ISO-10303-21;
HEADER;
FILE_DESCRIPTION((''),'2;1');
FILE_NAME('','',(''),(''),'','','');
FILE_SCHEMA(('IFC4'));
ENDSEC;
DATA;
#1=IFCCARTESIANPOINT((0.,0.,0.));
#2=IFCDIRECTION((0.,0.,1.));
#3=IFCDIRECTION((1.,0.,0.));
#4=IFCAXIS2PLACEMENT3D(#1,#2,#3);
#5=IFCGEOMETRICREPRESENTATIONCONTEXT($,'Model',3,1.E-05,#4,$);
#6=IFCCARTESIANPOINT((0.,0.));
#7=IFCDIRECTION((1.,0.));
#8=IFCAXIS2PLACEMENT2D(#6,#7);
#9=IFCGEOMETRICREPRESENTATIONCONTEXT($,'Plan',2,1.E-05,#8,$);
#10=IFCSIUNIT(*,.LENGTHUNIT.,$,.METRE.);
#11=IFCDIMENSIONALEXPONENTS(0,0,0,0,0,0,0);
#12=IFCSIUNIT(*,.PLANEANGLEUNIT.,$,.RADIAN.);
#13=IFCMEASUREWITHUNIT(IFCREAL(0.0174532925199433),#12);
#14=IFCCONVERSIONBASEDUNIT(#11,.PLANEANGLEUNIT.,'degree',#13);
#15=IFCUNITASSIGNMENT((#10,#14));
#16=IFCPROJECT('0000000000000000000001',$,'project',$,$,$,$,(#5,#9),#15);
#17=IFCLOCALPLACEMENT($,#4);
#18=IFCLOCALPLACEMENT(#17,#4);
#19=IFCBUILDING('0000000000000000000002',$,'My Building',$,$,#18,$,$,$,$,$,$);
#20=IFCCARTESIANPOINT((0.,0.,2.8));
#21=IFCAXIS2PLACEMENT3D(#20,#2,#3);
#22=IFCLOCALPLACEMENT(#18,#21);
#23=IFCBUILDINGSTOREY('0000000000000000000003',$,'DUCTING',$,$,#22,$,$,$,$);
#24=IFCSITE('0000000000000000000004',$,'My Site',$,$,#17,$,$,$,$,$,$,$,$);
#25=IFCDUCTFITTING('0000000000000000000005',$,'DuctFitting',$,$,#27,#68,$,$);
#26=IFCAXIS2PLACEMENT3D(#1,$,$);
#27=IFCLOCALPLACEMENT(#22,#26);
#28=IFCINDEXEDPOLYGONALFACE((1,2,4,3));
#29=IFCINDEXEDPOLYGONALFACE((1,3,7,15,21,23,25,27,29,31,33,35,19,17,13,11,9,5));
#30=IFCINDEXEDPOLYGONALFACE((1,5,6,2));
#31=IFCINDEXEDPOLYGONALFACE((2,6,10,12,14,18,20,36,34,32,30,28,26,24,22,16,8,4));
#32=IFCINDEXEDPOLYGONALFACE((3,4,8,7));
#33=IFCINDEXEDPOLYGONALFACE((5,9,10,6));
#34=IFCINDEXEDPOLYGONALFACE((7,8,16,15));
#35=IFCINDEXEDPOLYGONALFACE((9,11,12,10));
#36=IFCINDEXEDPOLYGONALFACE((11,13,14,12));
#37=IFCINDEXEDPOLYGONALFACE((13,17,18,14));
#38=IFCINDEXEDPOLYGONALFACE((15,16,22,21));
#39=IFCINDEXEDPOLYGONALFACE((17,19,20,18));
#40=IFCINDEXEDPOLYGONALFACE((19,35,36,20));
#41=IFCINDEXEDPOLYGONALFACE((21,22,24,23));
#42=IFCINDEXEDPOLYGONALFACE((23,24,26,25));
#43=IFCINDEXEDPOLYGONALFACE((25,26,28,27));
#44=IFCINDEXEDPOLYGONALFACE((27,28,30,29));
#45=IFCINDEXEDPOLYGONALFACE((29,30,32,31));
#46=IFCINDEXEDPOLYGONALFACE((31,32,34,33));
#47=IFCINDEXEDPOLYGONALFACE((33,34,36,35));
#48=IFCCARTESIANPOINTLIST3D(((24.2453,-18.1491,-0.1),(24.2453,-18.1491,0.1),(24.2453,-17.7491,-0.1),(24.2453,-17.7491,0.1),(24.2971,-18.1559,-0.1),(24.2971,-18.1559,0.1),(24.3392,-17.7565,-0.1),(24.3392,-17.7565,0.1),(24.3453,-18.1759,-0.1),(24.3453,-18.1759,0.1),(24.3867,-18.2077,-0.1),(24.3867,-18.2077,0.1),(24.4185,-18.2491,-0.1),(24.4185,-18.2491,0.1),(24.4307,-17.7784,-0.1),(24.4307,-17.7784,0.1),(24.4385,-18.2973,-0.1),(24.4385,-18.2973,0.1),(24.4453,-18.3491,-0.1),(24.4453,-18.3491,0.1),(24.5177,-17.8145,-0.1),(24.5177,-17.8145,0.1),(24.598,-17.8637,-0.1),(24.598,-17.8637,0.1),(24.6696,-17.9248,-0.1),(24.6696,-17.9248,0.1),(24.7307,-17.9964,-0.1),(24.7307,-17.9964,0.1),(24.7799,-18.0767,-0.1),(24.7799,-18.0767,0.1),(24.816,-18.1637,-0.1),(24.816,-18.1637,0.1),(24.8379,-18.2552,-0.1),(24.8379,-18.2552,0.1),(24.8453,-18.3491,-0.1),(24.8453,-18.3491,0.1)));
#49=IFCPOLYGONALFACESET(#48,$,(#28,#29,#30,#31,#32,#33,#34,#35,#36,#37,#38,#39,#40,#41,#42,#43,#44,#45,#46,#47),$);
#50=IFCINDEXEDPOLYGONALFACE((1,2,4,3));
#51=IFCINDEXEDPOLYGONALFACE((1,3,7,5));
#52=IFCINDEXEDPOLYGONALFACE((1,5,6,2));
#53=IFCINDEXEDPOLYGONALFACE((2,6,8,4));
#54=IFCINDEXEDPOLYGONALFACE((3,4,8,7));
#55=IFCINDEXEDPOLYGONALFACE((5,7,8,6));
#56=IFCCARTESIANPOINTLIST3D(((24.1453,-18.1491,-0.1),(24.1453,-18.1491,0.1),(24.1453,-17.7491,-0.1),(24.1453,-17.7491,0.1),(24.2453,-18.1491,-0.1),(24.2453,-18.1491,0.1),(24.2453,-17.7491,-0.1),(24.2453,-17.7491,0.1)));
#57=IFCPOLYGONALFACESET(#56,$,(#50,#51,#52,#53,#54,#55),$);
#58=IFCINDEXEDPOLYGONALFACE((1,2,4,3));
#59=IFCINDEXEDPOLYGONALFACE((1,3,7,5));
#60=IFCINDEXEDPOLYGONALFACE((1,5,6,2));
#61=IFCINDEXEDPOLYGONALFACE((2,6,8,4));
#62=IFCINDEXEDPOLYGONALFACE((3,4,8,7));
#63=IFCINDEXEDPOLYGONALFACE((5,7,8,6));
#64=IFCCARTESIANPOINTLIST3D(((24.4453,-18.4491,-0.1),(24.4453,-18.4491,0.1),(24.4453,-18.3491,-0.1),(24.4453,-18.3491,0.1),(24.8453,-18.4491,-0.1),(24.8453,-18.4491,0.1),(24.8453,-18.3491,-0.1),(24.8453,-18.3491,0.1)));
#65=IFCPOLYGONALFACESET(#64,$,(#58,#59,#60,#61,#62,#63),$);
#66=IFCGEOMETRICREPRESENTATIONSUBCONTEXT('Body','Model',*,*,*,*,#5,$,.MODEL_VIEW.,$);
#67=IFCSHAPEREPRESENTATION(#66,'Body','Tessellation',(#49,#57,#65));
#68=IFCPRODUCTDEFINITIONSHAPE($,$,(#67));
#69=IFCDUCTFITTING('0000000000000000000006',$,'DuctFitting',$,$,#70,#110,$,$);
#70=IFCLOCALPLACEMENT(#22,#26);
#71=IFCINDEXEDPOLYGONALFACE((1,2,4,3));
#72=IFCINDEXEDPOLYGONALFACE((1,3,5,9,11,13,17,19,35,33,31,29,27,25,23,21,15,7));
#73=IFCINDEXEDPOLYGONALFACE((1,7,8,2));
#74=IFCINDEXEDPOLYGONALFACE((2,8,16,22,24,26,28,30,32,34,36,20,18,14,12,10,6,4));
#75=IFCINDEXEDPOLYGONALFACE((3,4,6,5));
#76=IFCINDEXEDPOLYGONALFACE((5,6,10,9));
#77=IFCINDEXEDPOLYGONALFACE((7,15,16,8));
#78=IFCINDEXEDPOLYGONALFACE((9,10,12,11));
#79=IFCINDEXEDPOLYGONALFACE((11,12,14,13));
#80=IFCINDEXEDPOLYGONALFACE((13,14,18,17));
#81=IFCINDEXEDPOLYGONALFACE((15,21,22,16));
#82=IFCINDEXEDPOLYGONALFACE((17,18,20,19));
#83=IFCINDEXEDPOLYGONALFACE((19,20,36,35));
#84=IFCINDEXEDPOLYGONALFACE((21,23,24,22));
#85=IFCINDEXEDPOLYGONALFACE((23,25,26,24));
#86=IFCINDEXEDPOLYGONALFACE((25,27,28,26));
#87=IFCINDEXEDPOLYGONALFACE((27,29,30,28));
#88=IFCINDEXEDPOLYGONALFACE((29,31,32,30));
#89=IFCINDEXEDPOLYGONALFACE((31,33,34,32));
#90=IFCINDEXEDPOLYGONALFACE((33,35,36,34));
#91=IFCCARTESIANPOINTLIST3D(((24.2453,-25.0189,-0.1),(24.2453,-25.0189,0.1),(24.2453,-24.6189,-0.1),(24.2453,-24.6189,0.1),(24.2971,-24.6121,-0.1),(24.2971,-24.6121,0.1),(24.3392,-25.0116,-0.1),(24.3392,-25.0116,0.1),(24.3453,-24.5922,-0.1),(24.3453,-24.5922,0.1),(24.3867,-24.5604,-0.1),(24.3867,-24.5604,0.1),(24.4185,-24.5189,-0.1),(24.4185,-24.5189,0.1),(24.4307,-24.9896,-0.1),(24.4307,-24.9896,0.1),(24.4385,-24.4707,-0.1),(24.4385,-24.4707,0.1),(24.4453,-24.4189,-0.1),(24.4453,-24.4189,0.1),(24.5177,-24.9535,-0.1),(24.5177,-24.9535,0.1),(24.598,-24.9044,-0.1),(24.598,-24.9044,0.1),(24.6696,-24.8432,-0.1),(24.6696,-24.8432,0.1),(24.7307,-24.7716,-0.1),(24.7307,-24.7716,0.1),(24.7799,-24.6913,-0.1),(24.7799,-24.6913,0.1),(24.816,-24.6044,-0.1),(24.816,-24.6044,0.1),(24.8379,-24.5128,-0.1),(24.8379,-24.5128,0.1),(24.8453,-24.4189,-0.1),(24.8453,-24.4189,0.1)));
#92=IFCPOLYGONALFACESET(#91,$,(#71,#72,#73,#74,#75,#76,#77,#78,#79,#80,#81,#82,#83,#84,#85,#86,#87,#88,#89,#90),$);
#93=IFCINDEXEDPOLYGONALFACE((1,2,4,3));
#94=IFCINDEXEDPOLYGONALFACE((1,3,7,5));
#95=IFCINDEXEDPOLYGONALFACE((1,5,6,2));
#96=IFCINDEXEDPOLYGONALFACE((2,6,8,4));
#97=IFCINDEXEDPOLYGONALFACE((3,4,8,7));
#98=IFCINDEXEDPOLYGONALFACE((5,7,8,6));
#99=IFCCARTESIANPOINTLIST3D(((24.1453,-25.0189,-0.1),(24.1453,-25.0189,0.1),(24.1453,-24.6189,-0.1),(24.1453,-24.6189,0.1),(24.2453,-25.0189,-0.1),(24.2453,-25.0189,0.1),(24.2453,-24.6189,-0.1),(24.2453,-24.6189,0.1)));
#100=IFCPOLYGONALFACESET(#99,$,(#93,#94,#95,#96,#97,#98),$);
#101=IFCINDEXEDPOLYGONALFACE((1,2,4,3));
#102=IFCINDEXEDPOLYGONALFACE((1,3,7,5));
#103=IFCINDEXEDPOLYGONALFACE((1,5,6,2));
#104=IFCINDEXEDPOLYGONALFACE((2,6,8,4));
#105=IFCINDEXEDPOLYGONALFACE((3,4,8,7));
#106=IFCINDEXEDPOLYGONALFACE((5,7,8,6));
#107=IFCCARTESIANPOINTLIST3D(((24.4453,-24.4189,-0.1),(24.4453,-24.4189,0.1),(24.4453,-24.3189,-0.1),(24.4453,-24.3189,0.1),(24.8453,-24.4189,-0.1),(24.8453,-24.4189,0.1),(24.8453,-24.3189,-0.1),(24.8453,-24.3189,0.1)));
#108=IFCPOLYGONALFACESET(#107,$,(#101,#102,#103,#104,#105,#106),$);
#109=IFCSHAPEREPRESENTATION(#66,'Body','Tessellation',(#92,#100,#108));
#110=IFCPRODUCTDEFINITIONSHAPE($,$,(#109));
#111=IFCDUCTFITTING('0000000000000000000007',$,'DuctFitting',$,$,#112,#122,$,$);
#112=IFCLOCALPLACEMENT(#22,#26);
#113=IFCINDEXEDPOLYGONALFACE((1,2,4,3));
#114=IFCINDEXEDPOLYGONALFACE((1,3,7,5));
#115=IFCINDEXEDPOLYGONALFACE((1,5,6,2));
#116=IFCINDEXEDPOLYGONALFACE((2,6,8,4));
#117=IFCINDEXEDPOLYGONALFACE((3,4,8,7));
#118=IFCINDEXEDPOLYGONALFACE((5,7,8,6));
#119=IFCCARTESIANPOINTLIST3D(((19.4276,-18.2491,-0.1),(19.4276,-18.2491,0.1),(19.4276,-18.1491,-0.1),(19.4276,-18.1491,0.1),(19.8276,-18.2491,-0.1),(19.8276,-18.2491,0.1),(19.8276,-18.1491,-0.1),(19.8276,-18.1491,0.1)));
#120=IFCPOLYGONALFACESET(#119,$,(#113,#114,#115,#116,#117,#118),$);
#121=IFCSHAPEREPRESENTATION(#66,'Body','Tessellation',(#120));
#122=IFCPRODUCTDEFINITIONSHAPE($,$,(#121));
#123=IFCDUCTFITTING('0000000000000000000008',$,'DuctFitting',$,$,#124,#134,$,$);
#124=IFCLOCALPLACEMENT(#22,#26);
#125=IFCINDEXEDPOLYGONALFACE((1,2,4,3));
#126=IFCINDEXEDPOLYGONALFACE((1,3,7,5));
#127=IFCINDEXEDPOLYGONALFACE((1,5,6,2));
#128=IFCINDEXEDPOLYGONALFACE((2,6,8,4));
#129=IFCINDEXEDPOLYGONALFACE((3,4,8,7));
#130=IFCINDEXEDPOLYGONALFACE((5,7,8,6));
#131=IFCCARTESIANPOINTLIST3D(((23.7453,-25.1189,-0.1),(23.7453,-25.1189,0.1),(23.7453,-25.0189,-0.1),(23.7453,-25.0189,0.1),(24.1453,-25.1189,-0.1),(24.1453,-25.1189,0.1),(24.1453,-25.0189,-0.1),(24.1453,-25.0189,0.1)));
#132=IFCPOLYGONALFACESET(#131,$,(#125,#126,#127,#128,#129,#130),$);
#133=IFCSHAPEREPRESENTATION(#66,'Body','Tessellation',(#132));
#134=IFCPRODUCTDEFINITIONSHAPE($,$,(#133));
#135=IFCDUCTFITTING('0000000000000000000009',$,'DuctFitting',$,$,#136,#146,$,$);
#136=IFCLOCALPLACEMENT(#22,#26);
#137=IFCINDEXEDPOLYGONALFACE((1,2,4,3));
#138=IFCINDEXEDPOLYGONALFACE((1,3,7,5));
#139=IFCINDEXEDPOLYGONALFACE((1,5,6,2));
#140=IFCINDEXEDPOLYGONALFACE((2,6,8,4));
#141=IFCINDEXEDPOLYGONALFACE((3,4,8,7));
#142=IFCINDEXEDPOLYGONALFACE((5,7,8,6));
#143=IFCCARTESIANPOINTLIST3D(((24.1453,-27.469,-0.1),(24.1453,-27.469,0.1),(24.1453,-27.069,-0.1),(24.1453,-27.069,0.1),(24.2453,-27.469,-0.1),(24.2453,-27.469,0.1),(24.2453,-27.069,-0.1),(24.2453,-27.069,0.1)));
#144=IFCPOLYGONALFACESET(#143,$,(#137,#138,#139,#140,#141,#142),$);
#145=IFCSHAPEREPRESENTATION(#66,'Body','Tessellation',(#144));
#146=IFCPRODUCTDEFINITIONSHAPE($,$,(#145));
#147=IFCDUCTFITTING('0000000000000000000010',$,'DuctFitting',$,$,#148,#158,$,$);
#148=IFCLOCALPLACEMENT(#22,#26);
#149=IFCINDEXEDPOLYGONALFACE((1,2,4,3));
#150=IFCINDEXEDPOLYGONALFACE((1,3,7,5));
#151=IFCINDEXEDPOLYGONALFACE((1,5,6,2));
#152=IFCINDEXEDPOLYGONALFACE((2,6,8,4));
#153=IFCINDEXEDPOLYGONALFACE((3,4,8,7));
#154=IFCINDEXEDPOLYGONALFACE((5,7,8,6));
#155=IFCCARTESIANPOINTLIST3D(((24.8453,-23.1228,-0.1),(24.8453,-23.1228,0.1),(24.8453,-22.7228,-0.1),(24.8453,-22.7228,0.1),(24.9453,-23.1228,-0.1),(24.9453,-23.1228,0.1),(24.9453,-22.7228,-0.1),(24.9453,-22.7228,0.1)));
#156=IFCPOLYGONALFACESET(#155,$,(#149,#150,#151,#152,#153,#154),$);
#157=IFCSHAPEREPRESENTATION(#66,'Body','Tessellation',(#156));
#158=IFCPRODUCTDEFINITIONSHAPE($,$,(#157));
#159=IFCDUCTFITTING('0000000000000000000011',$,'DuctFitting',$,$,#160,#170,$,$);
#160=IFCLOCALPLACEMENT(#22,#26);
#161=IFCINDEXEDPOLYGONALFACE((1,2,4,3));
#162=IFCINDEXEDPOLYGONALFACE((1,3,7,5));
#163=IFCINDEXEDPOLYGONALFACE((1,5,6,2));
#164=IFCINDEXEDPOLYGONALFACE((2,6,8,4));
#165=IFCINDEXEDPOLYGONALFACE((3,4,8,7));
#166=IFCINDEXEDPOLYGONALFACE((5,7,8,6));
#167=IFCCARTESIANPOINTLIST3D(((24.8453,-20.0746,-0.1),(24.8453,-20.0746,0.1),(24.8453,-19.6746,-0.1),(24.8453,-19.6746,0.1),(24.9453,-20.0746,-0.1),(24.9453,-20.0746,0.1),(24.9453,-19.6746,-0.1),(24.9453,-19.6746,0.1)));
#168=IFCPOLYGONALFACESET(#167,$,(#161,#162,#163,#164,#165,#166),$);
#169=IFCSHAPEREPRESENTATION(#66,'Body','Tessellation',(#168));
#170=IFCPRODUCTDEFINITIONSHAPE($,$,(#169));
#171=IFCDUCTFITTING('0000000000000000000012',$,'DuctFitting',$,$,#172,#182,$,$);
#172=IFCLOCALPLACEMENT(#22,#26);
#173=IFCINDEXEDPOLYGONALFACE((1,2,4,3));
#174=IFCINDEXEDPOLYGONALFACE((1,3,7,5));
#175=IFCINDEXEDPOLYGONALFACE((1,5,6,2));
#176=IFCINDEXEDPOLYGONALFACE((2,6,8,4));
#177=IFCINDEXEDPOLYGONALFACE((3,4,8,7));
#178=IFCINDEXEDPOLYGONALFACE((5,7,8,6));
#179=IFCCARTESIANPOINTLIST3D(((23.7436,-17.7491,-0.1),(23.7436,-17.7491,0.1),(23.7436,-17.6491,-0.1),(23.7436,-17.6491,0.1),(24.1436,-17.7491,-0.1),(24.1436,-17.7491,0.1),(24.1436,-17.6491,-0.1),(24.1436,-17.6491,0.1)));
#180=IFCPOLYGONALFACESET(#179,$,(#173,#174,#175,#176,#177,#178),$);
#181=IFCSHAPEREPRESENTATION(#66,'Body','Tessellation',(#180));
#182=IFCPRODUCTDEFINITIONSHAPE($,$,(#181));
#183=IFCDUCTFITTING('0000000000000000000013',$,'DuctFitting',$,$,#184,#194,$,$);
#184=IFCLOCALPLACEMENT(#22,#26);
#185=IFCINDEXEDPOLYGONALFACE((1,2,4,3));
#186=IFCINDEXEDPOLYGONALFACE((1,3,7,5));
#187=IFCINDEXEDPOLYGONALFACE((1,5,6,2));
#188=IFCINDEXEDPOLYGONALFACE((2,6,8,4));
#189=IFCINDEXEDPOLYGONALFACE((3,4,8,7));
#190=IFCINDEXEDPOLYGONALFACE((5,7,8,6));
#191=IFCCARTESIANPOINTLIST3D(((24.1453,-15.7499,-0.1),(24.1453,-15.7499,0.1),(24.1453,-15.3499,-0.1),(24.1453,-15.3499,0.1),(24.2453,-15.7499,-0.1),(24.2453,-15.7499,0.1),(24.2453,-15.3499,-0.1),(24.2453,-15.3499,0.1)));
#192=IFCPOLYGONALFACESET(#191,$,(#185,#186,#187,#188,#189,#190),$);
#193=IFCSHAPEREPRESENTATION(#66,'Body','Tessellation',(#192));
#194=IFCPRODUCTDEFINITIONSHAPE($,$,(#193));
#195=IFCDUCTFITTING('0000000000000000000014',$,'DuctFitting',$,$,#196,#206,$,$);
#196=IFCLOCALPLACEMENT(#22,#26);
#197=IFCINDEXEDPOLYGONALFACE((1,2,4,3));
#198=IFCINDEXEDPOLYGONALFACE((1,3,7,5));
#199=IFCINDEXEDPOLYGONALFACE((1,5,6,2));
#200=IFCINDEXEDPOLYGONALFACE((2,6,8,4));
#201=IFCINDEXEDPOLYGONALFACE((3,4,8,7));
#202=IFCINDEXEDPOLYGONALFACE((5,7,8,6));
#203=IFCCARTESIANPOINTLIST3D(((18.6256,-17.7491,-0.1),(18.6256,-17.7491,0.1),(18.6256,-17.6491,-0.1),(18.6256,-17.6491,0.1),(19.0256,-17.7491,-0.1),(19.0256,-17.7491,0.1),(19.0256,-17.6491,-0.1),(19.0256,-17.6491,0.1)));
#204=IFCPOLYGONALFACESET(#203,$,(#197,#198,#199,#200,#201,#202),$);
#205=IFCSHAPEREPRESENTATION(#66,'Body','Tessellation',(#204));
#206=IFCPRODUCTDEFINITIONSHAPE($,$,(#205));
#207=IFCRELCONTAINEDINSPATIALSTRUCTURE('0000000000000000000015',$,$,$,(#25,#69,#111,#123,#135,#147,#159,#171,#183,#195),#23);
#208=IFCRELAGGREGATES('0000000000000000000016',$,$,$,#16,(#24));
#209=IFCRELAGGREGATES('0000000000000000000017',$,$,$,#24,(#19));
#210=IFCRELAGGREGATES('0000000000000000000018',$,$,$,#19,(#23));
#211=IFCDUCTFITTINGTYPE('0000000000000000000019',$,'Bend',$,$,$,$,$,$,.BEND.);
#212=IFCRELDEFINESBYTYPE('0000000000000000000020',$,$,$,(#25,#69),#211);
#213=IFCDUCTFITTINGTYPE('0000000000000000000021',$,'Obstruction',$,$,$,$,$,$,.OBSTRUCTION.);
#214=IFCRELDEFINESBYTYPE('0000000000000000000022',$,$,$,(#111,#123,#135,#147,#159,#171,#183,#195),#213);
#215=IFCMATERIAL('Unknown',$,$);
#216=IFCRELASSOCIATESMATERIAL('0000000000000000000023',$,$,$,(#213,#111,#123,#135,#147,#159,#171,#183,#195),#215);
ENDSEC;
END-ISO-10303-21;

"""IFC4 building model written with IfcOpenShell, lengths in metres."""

from ifc_helpers import new_model, entity, si_unit, converted_unit, frame, origin_with_axes, origin_2d_with_axis, place, context, subcontext, project, spatial, line, arc, indexed_curve, rectangle, outline, extrude, source, transform, mapped, material, material_profile, profile_set, profile_usage, type_object, type_shapes, element, save


model = new_model("IFC4")

# Units and contexts
model_context = context("Model", 3, precision=1e-05, world=origin_with_axes())
plan_context = context("Plan", 2, precision=1e-05, world=origin_2d_with_axis())
body_context = subcontext(model_context, "Body", "Model", "MODEL_VIEW")
ifc_project = project(units=[si_unit("LENGTHUNIT", "METRE"), converted_unit("PLANEANGLEUNIT", "degree", entity("IfcReal", 0.0174532925199433), si_unit("PLANEANGLEUNIT", "RADIAN"), dimensions=[0, 0, 0, 0, 0, 0, 0])], contexts=[model_context, plan_context])

# Site, building, storey
site_placement = place(None, origin_with_axes())
site = spatial("IfcSite", under=ifc_project, at=site_placement, Name="My Site")
building_placement = place(site_placement, origin_with_axes())
building = spatial("IfcBuilding", under=site, at=building_placement, Name="My Building")
storey_placement = place(building_placement, frame((0.0, 0.0, 2.8), z_axis=(0.0, 0.0, 1.0), x_axis=(1.0, 0.0, 0.0)))
storey = spatial("IfcBuildingStorey", under=building, at=storey_placement, Name="DUCTING")

# Shared definitions
ifc_material = material(Name="Unknown")

# Duct fittings
duct_fitting_type_1 = type_object("IfcDuctFittingType", Name="Bend", PredefinedType="BEND")
shared_shape = source(origin_with_axes(), body_context, "Body", "SweptSolid", [
    extrude(outline(indexed_curve([(-0.2, 0.0), (-0.2586, 0.1414), (-0.4, 0.2), (-0.4, 0.6), (0.0243, 0.4243), (0.2, 0.0)], segments=[arc(1, 2, 3), line(3, 4), arc(4, 5, 6), line(6, 1)])), frame((0.0, -0.1, 0.1), z_axis=(0.0, -1.0, 0.0), x_axis=(1.0, 0.0, 0.0)), (0.0, 0.0, -1.0), 0.2),
    extrude(rectangle(XDim=0.4, YDim=0.2), origin_with_axes(), (0.0, 0.0, 1.0), 0.1),
    extrude(rectangle(XDim=0.4, YDim=0.2), frame((-0.4, 0.0, 0.5), z_axis=(-1.0, 0.0, 0.000001), x_axis=(-0.000001, 0.0, -1.0)), (0.0, 0.0, 1.0), 0.1),
])
type_shapes(duct_fitting_type_1, [shared_shape])
for number, where, z_axis, x_axis, name in (
    (1, (24.1453, -17.9491, 0.0), (1.0, -0.000001, 0.000001), (0.000001, 1.0, 0.0), "DuctFitting"),
    (2, (24.1453, -24.8189, 0.0), (1.0, -0.000001, 0.000001), (-0.000001, -1.0, 0.0), "DuctFitting"),
):
    element("IfcDuctFitting", number, at=place(storey_placement, frame(where, z_axis=z_axis, x_axis=x_axis)), inside=storey, type_object=duct_fitting_type_1, Name=name, context=body_context, shape_type="MappedRepresentation", body=[
        mapped(shared_shape, transform((0.0, 0.0, 0.0), x_axis=(1.0, 0.0, 0.0), y_axis=(0.0, 1.0, 0.0), z_axis=(0.0, 0.0, 1.0), scale=1.0)),
    ])
ifc_material_profile_1 = material_profile(ifc_material, rectangle(XDim=0.4, YDim=0.2))
ifc_profile_set_1 = profile_set([ifc_material_profile_1])
ifc_profile_usage_1 = profile_usage(ifc_profile_set_1, cardinal=5)
duct_fitting_type_2 = type_object("IfcDuctFittingType", Name="Obstruction", PredefinedType="OBSTRUCTION", material=ifc_profile_set_1)
duct_fitting_1_placement = place(storey_placement, frame((19.6276, -18.1491, 0.0), z_axis=(0.000001, -1.0, 0.0), x_axis=(1.0, 0.000001, 0.0)))
element("IfcDuctFitting", 3, at=duct_fitting_1_placement, inside=storey, type_object=duct_fitting_type_2, material=ifc_profile_usage_1, Name="DuctFitting", context=body_context, shape_type="SweptSolid", body=[
    extrude(rectangle(XDim=0.4, YDim=0.2), origin_with_axes(), (0.0, 0.0, 1.0), 0.1),
])
ifc_profile_usage_2 = profile_usage(ifc_profile_set_1, cardinal=5)
duct_fitting_2_placement = place(storey_placement, frame((23.9453, -25.0189, 0.0), z_axis=(0.0, -1.0, 0.0), x_axis=(1.0, 0.0, 0.0)))
element("IfcDuctFitting", 4, at=duct_fitting_2_placement, inside=storey, type_object=duct_fitting_type_2, material=ifc_profile_usage_2, Name="DuctFitting", context=body_context, shape_type="SweptSolid", body=[
    extrude(rectangle(XDim=0.4, YDim=0.2), origin_with_axes(), (0.0, 0.0, 1.0), 0.1),
])
ifc_profile_usage_3 = profile_usage(ifc_profile_set_1, cardinal=5)
duct_fitting_3_placement = place(storey_placement, frame((24.1453, -27.269, 0.0), z_axis=(1.0, 0.0, 0.0), x_axis=(0.0, 1.0, 0.0)))
element("IfcDuctFitting", 5, at=duct_fitting_3_placement, inside=storey, type_object=duct_fitting_type_2, material=ifc_profile_usage_3, Name="DuctFitting", context=body_context, shape_type="SweptSolid", body=[
    extrude(rectangle(XDim=0.4, YDim=0.2), origin_with_axes(), (0.0, 0.0, 1.0), 0.1),
])
ifc_profile_usage_4 = profile_usage(ifc_profile_set_1, cardinal=5)
duct_fitting_4_placement = place(storey_placement, frame((24.8453, -22.9228, 0.0), z_axis=(1.0, 0.0, 0.0), x_axis=(0.0, 1.0, 0.0)))
element("IfcDuctFitting", 6, at=duct_fitting_4_placement, inside=storey, type_object=duct_fitting_type_2, material=ifc_profile_usage_4, Name="DuctFitting", context=body_context, shape_type="SweptSolid", body=[
    extrude(rectangle(XDim=0.4, YDim=0.2), origin_with_axes(), (0.0, 0.0, 1.0), 0.1),
])
ifc_profile_usage_5 = profile_usage(ifc_profile_set_1, cardinal=5)
duct_fitting_5_placement = place(storey_placement, frame((24.8453, -19.8746, 0.0), z_axis=(1.0, 0.0, 0.0), x_axis=(0.0, 1.0, 0.0)))
element("IfcDuctFitting", 7, at=duct_fitting_5_placement, inside=storey, type_object=duct_fitting_type_2, material=ifc_profile_usage_5, Name="DuctFitting", context=body_context, shape_type="SweptSolid", body=[
    extrude(rectangle(XDim=0.4, YDim=0.2), origin_with_axes(), (0.0, 0.0, 1.0), 0.1),
])
ifc_profile_usage_6 = profile_usage(ifc_profile_set_1, cardinal=5)
duct_fitting_6_placement = place(storey_placement, frame((23.9436, -17.6491, 0.0), z_axis=(0.0, -1.0, 0.0), x_axis=(1.0, 0.0, 0.0)))
element("IfcDuctFitting", 8, at=duct_fitting_6_placement, inside=storey, type_object=duct_fitting_type_2, material=ifc_profile_usage_6, Name="DuctFitting", context=body_context, shape_type="SweptSolid", body=[
    extrude(rectangle(XDim=0.4, YDim=0.2), origin_with_axes(), (0.0, 0.0, 1.0), 0.1),
])
ifc_profile_usage_7 = profile_usage(ifc_profile_set_1, cardinal=5)
duct_fitting_7_placement = place(storey_placement, frame((24.1453, -15.5499, 0.0), z_axis=(1.0, 0.0, 0.0), x_axis=(0.0, 1.0, 0.0)))
element("IfcDuctFitting", 9, at=duct_fitting_7_placement, inside=storey, type_object=duct_fitting_type_2, material=ifc_profile_usage_7, Name="DuctFitting", context=body_context, shape_type="SweptSolid", body=[
    extrude(rectangle(XDim=0.4, YDim=0.2), origin_with_axes(), (0.0, 0.0, 1.0), 0.1),
])
ifc_profile_usage_8 = profile_usage(ifc_profile_set_1, cardinal=5)
duct_fitting_8_placement = place(storey_placement, frame((18.8256, -17.6491, 0.0), z_axis=(0.0, -1.0, 0.0), x_axis=(1.0, 0.0, 0.0)))
element("IfcDuctFitting", 10, at=duct_fitting_8_placement, inside=storey, type_object=duct_fitting_type_2, material=ifc_profile_usage_8, Name="DuctFitting", context=body_context, shape_type="SweptSolid", body=[
    extrude(rectangle(XDim=0.4, YDim=0.2), origin_with_axes(), (0.0, 0.0, 1.0), 0.1),
])

save(model, "model.ifc")
